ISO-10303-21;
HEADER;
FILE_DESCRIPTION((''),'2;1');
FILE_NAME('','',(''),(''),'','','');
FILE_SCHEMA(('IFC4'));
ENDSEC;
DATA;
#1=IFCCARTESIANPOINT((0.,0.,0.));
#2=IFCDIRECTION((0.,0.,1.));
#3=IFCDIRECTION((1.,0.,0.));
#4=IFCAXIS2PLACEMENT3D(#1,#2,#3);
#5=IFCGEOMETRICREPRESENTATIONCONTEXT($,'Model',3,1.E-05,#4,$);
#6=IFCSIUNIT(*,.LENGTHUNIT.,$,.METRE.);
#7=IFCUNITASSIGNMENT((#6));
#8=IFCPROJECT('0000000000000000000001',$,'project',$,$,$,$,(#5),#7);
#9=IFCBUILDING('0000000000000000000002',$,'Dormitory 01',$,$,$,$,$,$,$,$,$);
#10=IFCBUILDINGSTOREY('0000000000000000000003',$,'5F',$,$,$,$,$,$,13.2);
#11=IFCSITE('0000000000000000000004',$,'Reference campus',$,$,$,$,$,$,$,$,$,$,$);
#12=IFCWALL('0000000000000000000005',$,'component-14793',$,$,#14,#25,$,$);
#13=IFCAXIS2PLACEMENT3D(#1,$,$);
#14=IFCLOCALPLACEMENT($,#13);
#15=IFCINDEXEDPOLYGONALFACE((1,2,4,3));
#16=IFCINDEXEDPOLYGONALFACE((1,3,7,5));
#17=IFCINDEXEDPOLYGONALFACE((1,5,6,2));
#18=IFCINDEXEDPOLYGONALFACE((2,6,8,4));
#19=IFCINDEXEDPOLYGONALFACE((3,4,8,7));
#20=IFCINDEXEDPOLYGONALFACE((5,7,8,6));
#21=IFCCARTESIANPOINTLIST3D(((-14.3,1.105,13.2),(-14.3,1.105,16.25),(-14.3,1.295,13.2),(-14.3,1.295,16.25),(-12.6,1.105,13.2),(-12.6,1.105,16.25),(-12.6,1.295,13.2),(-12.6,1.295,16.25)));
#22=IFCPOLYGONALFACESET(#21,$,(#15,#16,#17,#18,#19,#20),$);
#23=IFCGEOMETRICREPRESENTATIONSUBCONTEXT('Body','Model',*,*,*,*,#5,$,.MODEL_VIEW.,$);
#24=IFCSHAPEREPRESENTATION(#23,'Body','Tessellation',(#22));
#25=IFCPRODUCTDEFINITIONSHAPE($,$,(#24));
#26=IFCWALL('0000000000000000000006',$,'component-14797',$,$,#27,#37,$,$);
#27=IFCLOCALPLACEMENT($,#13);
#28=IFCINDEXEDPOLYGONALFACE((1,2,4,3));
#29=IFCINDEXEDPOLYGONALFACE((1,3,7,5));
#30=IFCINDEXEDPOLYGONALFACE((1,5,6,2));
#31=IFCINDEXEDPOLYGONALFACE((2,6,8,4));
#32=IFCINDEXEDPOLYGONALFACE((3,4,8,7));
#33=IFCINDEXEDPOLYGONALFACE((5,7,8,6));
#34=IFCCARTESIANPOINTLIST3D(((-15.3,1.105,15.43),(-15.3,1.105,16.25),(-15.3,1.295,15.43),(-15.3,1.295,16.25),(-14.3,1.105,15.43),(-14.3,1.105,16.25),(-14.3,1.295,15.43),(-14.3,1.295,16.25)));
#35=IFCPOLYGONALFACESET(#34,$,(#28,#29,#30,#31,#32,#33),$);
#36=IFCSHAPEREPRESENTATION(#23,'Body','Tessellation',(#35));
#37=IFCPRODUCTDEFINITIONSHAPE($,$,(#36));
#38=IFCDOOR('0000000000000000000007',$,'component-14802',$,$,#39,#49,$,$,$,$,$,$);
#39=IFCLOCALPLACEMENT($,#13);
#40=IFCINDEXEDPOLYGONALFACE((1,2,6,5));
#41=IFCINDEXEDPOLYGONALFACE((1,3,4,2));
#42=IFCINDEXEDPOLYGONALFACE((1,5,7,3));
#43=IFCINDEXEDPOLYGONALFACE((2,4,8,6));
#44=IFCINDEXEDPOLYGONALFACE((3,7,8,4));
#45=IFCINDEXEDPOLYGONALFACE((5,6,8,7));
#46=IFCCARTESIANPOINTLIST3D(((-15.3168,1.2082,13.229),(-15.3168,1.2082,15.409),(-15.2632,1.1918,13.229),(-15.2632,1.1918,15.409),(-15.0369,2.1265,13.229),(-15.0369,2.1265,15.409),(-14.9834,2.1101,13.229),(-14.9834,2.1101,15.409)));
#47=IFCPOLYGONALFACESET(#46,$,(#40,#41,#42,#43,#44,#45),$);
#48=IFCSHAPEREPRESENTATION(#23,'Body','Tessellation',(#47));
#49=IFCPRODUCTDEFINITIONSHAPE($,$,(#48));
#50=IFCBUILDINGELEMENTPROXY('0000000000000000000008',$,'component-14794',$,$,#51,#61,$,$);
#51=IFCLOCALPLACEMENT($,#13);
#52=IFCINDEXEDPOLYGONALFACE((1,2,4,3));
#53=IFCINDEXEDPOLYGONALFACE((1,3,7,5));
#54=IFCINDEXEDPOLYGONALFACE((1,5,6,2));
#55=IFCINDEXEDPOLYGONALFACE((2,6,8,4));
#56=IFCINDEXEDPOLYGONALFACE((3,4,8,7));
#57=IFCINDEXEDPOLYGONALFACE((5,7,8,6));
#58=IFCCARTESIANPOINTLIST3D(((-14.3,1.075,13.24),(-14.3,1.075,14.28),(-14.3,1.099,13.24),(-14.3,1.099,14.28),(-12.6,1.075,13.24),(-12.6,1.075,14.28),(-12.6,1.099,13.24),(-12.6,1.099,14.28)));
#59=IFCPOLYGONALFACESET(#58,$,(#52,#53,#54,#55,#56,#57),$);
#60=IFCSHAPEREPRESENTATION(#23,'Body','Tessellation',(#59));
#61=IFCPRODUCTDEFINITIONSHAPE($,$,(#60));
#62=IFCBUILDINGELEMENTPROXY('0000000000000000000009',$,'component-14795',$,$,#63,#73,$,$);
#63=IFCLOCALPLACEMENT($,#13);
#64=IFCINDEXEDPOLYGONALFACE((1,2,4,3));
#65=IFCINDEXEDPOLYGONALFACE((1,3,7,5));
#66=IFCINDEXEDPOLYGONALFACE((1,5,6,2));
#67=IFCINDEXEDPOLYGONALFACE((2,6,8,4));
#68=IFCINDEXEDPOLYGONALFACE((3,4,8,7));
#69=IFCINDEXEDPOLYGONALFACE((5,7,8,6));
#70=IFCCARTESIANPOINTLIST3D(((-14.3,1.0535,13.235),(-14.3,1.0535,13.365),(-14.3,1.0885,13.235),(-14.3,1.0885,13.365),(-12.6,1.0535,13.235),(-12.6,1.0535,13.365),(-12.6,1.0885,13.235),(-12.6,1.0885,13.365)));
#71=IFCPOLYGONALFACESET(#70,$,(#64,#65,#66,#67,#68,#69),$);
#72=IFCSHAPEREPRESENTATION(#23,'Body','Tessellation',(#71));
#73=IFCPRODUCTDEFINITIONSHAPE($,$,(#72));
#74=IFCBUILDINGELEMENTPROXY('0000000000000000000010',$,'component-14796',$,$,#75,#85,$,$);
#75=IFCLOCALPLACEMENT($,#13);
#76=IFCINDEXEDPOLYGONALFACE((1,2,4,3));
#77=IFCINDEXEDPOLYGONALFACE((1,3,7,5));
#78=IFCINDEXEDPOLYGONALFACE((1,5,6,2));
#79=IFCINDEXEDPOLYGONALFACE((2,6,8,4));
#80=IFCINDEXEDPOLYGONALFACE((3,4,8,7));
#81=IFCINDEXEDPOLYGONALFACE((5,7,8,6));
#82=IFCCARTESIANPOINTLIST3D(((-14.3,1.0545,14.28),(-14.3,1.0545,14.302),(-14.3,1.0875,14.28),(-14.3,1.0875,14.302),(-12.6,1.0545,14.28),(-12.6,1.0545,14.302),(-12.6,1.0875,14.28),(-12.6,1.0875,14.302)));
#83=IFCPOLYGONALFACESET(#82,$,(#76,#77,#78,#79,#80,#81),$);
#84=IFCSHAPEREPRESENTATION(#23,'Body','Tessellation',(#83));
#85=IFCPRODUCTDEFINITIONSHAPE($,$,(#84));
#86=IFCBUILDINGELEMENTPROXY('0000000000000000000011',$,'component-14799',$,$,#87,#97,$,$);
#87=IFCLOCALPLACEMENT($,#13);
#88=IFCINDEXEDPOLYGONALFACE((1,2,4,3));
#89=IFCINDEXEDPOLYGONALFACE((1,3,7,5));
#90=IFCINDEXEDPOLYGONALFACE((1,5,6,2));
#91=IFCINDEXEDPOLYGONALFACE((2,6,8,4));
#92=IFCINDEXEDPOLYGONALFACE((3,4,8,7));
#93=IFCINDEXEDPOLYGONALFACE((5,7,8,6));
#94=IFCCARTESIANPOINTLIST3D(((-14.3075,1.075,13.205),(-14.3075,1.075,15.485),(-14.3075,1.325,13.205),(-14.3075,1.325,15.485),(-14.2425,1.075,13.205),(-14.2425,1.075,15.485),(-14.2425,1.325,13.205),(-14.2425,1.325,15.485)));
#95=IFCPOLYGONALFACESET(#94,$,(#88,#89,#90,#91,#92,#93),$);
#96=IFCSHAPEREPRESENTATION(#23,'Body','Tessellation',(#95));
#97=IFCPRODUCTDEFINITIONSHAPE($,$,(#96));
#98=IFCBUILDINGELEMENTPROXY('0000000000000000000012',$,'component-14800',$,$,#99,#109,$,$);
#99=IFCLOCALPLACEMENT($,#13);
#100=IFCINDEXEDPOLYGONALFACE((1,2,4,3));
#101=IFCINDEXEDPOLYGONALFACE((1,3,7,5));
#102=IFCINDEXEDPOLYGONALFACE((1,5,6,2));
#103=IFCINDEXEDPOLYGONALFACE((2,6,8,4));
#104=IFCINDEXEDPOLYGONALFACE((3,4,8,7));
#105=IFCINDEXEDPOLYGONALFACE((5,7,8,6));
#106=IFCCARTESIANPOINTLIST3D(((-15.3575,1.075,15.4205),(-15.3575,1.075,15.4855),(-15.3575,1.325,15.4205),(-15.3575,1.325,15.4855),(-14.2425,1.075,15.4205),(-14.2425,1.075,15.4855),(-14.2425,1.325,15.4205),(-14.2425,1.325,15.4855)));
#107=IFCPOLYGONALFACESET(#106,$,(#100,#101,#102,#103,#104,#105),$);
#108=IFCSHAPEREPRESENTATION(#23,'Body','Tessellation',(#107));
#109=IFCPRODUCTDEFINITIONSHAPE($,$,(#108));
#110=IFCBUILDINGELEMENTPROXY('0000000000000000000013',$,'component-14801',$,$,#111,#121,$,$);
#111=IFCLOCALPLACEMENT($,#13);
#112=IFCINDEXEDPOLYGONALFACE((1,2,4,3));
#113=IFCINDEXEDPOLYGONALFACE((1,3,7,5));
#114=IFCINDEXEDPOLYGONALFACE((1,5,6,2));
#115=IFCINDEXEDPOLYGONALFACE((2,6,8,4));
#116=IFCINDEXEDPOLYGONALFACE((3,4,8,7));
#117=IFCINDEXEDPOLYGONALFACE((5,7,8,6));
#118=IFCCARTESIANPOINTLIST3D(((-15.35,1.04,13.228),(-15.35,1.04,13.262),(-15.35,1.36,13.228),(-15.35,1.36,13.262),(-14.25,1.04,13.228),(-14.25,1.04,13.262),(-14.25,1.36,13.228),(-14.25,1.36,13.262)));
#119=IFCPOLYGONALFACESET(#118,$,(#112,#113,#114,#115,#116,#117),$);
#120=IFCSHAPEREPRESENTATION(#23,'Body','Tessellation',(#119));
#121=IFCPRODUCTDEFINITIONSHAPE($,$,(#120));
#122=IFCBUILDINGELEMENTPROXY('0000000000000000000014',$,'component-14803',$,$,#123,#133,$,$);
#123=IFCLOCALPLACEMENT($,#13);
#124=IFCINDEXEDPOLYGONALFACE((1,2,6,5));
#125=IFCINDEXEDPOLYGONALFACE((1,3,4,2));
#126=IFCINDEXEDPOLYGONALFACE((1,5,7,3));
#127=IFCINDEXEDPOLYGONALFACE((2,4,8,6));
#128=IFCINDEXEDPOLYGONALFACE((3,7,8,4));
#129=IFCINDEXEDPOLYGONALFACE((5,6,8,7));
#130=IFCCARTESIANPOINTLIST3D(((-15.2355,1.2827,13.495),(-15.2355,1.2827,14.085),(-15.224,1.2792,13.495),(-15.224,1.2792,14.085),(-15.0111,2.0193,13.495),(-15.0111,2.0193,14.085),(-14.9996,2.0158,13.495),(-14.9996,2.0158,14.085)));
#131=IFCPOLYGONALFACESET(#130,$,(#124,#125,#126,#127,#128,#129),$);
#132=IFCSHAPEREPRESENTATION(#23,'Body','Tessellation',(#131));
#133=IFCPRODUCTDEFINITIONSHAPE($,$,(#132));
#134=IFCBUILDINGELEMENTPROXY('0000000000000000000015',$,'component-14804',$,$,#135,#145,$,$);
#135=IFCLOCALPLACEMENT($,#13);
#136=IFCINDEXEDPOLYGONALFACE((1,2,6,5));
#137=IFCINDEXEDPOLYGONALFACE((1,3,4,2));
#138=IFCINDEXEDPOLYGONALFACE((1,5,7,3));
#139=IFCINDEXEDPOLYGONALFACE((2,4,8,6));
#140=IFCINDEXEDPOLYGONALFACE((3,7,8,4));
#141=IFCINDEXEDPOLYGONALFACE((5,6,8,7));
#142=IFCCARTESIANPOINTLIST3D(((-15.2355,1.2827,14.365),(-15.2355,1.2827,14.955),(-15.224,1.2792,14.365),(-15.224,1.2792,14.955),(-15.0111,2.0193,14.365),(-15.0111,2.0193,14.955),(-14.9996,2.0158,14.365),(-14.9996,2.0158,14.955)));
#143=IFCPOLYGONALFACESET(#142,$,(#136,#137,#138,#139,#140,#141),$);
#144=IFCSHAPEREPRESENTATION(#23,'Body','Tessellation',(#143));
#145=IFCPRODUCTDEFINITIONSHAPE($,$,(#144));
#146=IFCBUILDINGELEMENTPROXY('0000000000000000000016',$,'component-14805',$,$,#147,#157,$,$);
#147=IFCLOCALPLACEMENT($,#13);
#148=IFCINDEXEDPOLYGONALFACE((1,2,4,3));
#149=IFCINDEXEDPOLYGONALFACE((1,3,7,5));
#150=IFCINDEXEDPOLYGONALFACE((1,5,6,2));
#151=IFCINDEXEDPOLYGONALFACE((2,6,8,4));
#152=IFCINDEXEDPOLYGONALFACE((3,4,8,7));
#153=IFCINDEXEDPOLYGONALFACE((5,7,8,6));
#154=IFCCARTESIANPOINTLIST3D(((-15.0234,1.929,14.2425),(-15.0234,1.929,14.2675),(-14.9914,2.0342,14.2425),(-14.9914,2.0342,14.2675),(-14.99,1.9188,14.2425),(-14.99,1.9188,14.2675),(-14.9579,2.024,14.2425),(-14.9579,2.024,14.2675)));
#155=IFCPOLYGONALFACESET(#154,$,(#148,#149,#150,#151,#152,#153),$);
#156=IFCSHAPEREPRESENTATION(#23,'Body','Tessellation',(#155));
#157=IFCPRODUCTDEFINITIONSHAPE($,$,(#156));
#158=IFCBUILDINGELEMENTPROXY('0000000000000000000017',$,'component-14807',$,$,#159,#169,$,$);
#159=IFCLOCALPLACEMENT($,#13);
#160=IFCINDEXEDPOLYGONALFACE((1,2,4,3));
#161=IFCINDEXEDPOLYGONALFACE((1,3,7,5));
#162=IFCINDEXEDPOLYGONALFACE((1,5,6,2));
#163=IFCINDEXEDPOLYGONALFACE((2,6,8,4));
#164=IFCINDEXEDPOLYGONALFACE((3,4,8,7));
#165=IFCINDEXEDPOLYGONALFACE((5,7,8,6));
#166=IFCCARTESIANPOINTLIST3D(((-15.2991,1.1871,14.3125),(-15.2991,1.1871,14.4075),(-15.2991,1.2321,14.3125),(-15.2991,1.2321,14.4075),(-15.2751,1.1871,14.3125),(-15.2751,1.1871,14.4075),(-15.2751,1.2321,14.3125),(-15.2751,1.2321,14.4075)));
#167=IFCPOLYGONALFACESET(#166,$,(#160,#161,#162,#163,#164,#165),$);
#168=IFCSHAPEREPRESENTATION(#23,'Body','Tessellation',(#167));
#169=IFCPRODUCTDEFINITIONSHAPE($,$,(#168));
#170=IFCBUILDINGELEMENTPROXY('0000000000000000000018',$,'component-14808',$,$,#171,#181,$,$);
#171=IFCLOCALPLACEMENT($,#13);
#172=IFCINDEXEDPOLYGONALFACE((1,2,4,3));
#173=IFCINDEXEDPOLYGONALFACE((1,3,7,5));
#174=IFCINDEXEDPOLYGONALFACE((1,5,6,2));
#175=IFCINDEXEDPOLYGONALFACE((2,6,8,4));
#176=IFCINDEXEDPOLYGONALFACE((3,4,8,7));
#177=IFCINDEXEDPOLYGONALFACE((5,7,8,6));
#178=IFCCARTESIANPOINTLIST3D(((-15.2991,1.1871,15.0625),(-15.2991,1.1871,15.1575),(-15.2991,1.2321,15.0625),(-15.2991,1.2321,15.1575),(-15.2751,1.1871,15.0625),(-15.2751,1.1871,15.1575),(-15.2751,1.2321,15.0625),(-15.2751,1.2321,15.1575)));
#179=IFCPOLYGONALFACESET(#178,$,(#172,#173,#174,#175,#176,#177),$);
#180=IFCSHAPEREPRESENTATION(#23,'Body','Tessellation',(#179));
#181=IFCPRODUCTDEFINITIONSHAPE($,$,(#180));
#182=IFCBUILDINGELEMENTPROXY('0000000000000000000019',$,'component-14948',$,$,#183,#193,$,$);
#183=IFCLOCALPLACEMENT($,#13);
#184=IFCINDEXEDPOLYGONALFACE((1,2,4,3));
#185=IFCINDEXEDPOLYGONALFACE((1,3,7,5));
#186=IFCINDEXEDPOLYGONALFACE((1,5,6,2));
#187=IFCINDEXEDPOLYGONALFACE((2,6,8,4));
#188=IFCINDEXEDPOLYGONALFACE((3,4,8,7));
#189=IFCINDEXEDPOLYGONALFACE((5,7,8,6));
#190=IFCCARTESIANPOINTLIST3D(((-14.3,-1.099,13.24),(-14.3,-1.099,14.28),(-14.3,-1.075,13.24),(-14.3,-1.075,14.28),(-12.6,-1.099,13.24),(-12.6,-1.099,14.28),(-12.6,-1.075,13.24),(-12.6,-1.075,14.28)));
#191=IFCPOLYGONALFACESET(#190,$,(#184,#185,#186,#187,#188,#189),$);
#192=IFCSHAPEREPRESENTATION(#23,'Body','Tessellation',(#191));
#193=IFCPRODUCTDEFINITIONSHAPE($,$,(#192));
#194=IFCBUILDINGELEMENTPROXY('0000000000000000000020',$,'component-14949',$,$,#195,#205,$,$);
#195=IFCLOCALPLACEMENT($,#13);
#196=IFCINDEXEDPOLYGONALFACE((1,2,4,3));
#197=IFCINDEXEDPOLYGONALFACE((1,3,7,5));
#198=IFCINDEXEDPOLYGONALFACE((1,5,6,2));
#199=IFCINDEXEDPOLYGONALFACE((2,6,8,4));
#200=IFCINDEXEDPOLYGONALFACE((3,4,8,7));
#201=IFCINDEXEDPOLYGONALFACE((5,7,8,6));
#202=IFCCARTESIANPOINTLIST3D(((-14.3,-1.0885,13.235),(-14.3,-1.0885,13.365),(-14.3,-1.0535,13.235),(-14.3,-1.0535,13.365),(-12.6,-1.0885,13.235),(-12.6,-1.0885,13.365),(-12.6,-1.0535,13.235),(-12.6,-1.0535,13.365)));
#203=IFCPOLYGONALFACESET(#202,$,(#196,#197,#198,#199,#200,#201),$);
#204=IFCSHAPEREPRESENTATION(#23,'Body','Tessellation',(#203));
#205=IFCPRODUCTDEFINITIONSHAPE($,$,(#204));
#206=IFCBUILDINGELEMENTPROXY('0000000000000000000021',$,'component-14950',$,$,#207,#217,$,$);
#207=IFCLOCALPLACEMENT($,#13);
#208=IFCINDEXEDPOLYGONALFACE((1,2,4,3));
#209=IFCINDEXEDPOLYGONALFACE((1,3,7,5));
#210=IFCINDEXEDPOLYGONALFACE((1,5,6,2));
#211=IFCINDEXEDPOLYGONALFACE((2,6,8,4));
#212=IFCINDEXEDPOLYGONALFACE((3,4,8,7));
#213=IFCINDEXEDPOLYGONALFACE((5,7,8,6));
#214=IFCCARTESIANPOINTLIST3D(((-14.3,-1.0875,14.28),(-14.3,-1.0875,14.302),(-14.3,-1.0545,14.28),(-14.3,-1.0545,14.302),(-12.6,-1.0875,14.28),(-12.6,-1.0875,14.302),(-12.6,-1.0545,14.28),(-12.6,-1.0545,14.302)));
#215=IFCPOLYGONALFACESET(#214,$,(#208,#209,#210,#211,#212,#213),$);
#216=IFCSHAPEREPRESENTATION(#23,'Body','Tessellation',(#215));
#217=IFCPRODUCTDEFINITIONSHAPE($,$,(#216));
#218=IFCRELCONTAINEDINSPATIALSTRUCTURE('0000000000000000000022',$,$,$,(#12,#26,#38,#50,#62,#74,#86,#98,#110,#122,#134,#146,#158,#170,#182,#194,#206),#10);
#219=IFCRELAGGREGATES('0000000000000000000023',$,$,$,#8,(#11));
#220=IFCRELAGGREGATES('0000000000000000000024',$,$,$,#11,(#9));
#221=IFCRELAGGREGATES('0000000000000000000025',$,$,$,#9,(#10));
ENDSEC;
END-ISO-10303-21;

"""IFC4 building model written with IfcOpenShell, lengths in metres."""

from ifc_helpers import new_model, si_unit, frame, origin, origin_with_axes, origin_2d, place, context, subcontext, project, spatial, rectangle, extrude, element, save


model = new_model("IFC4")

# Units and contexts
model_context = context("Model", 3, precision=1e-05, world=origin_with_axes())
body_context = subcontext(model_context, "Body", "Model", "MODEL_VIEW")
ifc_project = project(units=[si_unit("LENGTHUNIT", "METRE")], contexts=[model_context])

# Site, building, storey
site = spatial("IfcSite", under=ifc_project, Name="Reference campus")
building = spatial("IfcBuilding", under=site, Name="Dormitory 01")
storey = spatial("IfcBuildingStorey", under=building, Name="5F", Elevation=13.2)

# Walls
wall_1_placement = place(None, frame((-13.45, 1.2, 13.2), z_axis=(0.0, 0.0, 1.0), x_axis=(1.0, 0.0, 0.0)))
element("IfcWall", 1, at=wall_1_placement, inside=storey, Name="component-14793", context=body_context, shape_type="SweptSolid", body=[
    extrude(rectangle(XDim=1.7, YDim=0.19, at=origin_2d()), origin(), (0.0, 0.0, 1.0), 3.05),
])
wall_2_placement = place(None, frame((-14.8, 1.2, 15.43), z_axis=(0.0, 0.0, 1.0), x_axis=(1.0, 0.0, 0.0)))
element("IfcWall", 2, at=wall_2_placement, inside=storey, Name="component-14797", context=body_context, shape_type="SweptSolid", body=[
    extrude(rectangle(XDim=1.0, YDim=0.19, at=origin_2d()), origin(), (0.0, 0.0, 1.0), 0.82),
])

# Door
door_placement = place(None, frame((-15.1501, 1.6592, 13.229), z_axis=(0.0, 0.0, 1.0), x_axis=(0.291502, 0.95657, 0.0)))
element("IfcDoor", 3, at=door_placement, inside=storey, Name="component-14802", context=body_context, shape_type="SweptSolid", body=[
    extrude(rectangle(XDim=0.96, YDim=0.056, at=origin_2d()), origin(), (0.0, 0.0, 1.0), 2.18),
])

# Building element proxies
proxy_1_placement = place(None, frame((-13.45, 1.087, 13.24), z_axis=(0.0, 0.0, 1.0), x_axis=(1.0, 0.0, 0.0)))
element("IfcBuildingElementProxy", 4, at=proxy_1_placement, inside=storey, Name="component-14794", context=body_context, shape_type="SweptSolid", body=[
    extrude(rectangle(XDim=1.7, YDim=0.024, at=origin_2d()), origin(), (0.0, 0.0, 1.0), 1.04),
])
proxy_2_placement = place(None, frame((-13.45, 1.071, 13.235), z_axis=(0.0, 0.0, 1.0), x_axis=(1.0, 0.0, 0.0)))
element("IfcBuildingElementProxy", 5, at=proxy_2_placement, inside=storey, Name="component-14795", context=body_context, shape_type="SweptSolid", body=[
    extrude(rectangle(XDim=1.7, YDim=0.035, at=origin_2d()), origin(), (0.0, 0.0, 1.0), 0.13),
])
proxy_3_placement = place(None, frame((-13.45, 1.071, 14.28), z_axis=(0.0, 0.0, 1.0), x_axis=(1.0, 0.0, 0.0)))
element("IfcBuildingElementProxy", 6, at=proxy_3_placement, inside=storey, Name="component-14796", context=body_context, shape_type="SweptSolid", body=[
    extrude(rectangle(XDim=1.7, YDim=0.033, at=origin_2d()), origin(), (0.0, 0.0, 1.0), 0.022),
])
proxy_4_placement = place(None, frame((-14.275, 1.2, 13.205), z_axis=(0.0, 0.0, 1.0), x_axis=(1.0, 0.0, 0.0)))
element("IfcBuildingElementProxy", 7, at=proxy_4_placement, inside=storey, Name="component-14799", context=body_context, shape_type="SweptSolid", body=[
    extrude(rectangle(XDim=0.065, YDim=0.25, at=origin_2d()), origin(), (0.0, 0.0, 1.0), 2.28),
])
proxy_5_placement = place(None, frame((-14.8, 1.2, 15.4205), z_axis=(0.0, 0.0, 1.0), x_axis=(1.0, 0.0, 0.0)))
element("IfcBuildingElementProxy", 8, at=proxy_5_placement, inside=storey, Name="component-14800", context=body_context, shape_type="SweptSolid", body=[
    extrude(rectangle(XDim=1.115, YDim=0.25, at=origin_2d()), origin(), (0.0, 0.0, 1.0), 0.065),
])
proxy_6_placement = place(None, frame((-14.8, 1.2, 13.228), z_axis=(0.0, 0.0, 1.0), x_axis=(1.0, 0.0, 0.0)))
element("IfcBuildingElementProxy", 9, at=proxy_6_placement, inside=storey, Name="component-14801", context=body_context, shape_type="SweptSolid", body=[
    extrude(rectangle(XDim=1.1, YDim=0.32, at=origin_2d()), origin(), (0.0, 0.0, 1.0), 0.034),
])
for number, where, z_axis, x_axis, name in (
    (10, (-15.1176, 1.6492, 13.495), (0.0, 0.0, 1.0), (0.291502, 0.95657, 0.0), "component-14803"),
    (11, (-15.1176, 1.6492, 14.365), (0.0, 0.0, 1.0), (0.291502, 0.95657, 0.0), "component-14804"),
):
    element("IfcBuildingElementProxy", number, at=place(None, frame(where, z_axis=z_axis, x_axis=x_axis)), inside=storey, Name=name, context=body_context, shape_type="SweptSolid", body=[
        extrude(rectangle(XDim=0.77, YDim=0.012, at=origin_2d()), origin(), (0.0, 0.0, 1.0), 0.59),
    ])
proxy_7_placement = place(None, frame((-14.9907, 1.9765, 14.2425), z_axis=(0.0, 0.0, 1.0), x_axis=(0.291502, 0.95657, 0.0)))
element("IfcBuildingElementProxy", 12, at=proxy_7_placement, inside=storey, Name="component-14805", context=body_context, shape_type="SweptSolid", body=[
    extrude(rectangle(XDim=0.11, YDim=0.035, at=origin_2d()), origin(), (0.0, 0.0, 1.0), 0.025),
])
for number, where, z_axis, x_axis, name in (
    (13, (-15.2871, 1.2096, 14.3125), (0.0, 0.0, 1.0), (1.0, 0.0, 0.0), "component-14807"),
    (14, (-15.2871, 1.2096, 15.0625), (0.0, 0.0, 1.0), (1.0, 0.0, 0.0), "component-14808"),
):
    element("IfcBuildingElementProxy", number, at=place(None, frame(where, z_axis=z_axis, x_axis=x_axis)), inside=storey, Name=name, context=body_context, shape_type="SweptSolid", body=[
        extrude(rectangle(XDim=0.024, YDim=0.045, at=origin_2d()), origin(), (0.0, 0.0, 1.0), 0.095),
    ])
proxy_8_placement = place(None, frame((-13.45, -1.087, 13.24), z_axis=(0.0, 0.0, 1.0), x_axis=(1.0, 0.0, 0.0)))
element("IfcBuildingElementProxy", 15, at=proxy_8_placement, inside=storey, Name="component-14948", context=body_context, shape_type="SweptSolid", body=[
    extrude(rectangle(XDim=1.7, YDim=0.024, at=origin_2d()), origin(), (0.0, 0.0, 1.0), 1.04),
])
proxy_9_placement = place(None, frame((-13.45, -1.071, 13.235), z_axis=(0.0, 0.0, 1.0), x_axis=(1.0, 0.0, 0.0)))
element("IfcBuildingElementProxy", 16, at=proxy_9_placement, inside=storey, Name="component-14949", context=body_context, shape_type="SweptSolid", body=[
    extrude(rectangle(XDim=1.7, YDim=0.035, at=origin_2d()), origin(), (0.0, 0.0, 1.0), 0.13),
])
proxy_10_placement = place(None, frame((-13.45, -1.071, 14.28), z_axis=(0.0, 0.0, 1.0), x_axis=(1.0, 0.0, 0.0)))
element("IfcBuildingElementProxy", 17, at=proxy_10_placement, inside=storey, Name="component-14950", context=body_context, shape_type="SweptSolid", body=[
    extrude(rectangle(XDim=1.7, YDim=0.033, at=origin_2d()), origin(), (0.0, 0.0, 1.0), 0.022),
])

save(model, "model.ifc")
